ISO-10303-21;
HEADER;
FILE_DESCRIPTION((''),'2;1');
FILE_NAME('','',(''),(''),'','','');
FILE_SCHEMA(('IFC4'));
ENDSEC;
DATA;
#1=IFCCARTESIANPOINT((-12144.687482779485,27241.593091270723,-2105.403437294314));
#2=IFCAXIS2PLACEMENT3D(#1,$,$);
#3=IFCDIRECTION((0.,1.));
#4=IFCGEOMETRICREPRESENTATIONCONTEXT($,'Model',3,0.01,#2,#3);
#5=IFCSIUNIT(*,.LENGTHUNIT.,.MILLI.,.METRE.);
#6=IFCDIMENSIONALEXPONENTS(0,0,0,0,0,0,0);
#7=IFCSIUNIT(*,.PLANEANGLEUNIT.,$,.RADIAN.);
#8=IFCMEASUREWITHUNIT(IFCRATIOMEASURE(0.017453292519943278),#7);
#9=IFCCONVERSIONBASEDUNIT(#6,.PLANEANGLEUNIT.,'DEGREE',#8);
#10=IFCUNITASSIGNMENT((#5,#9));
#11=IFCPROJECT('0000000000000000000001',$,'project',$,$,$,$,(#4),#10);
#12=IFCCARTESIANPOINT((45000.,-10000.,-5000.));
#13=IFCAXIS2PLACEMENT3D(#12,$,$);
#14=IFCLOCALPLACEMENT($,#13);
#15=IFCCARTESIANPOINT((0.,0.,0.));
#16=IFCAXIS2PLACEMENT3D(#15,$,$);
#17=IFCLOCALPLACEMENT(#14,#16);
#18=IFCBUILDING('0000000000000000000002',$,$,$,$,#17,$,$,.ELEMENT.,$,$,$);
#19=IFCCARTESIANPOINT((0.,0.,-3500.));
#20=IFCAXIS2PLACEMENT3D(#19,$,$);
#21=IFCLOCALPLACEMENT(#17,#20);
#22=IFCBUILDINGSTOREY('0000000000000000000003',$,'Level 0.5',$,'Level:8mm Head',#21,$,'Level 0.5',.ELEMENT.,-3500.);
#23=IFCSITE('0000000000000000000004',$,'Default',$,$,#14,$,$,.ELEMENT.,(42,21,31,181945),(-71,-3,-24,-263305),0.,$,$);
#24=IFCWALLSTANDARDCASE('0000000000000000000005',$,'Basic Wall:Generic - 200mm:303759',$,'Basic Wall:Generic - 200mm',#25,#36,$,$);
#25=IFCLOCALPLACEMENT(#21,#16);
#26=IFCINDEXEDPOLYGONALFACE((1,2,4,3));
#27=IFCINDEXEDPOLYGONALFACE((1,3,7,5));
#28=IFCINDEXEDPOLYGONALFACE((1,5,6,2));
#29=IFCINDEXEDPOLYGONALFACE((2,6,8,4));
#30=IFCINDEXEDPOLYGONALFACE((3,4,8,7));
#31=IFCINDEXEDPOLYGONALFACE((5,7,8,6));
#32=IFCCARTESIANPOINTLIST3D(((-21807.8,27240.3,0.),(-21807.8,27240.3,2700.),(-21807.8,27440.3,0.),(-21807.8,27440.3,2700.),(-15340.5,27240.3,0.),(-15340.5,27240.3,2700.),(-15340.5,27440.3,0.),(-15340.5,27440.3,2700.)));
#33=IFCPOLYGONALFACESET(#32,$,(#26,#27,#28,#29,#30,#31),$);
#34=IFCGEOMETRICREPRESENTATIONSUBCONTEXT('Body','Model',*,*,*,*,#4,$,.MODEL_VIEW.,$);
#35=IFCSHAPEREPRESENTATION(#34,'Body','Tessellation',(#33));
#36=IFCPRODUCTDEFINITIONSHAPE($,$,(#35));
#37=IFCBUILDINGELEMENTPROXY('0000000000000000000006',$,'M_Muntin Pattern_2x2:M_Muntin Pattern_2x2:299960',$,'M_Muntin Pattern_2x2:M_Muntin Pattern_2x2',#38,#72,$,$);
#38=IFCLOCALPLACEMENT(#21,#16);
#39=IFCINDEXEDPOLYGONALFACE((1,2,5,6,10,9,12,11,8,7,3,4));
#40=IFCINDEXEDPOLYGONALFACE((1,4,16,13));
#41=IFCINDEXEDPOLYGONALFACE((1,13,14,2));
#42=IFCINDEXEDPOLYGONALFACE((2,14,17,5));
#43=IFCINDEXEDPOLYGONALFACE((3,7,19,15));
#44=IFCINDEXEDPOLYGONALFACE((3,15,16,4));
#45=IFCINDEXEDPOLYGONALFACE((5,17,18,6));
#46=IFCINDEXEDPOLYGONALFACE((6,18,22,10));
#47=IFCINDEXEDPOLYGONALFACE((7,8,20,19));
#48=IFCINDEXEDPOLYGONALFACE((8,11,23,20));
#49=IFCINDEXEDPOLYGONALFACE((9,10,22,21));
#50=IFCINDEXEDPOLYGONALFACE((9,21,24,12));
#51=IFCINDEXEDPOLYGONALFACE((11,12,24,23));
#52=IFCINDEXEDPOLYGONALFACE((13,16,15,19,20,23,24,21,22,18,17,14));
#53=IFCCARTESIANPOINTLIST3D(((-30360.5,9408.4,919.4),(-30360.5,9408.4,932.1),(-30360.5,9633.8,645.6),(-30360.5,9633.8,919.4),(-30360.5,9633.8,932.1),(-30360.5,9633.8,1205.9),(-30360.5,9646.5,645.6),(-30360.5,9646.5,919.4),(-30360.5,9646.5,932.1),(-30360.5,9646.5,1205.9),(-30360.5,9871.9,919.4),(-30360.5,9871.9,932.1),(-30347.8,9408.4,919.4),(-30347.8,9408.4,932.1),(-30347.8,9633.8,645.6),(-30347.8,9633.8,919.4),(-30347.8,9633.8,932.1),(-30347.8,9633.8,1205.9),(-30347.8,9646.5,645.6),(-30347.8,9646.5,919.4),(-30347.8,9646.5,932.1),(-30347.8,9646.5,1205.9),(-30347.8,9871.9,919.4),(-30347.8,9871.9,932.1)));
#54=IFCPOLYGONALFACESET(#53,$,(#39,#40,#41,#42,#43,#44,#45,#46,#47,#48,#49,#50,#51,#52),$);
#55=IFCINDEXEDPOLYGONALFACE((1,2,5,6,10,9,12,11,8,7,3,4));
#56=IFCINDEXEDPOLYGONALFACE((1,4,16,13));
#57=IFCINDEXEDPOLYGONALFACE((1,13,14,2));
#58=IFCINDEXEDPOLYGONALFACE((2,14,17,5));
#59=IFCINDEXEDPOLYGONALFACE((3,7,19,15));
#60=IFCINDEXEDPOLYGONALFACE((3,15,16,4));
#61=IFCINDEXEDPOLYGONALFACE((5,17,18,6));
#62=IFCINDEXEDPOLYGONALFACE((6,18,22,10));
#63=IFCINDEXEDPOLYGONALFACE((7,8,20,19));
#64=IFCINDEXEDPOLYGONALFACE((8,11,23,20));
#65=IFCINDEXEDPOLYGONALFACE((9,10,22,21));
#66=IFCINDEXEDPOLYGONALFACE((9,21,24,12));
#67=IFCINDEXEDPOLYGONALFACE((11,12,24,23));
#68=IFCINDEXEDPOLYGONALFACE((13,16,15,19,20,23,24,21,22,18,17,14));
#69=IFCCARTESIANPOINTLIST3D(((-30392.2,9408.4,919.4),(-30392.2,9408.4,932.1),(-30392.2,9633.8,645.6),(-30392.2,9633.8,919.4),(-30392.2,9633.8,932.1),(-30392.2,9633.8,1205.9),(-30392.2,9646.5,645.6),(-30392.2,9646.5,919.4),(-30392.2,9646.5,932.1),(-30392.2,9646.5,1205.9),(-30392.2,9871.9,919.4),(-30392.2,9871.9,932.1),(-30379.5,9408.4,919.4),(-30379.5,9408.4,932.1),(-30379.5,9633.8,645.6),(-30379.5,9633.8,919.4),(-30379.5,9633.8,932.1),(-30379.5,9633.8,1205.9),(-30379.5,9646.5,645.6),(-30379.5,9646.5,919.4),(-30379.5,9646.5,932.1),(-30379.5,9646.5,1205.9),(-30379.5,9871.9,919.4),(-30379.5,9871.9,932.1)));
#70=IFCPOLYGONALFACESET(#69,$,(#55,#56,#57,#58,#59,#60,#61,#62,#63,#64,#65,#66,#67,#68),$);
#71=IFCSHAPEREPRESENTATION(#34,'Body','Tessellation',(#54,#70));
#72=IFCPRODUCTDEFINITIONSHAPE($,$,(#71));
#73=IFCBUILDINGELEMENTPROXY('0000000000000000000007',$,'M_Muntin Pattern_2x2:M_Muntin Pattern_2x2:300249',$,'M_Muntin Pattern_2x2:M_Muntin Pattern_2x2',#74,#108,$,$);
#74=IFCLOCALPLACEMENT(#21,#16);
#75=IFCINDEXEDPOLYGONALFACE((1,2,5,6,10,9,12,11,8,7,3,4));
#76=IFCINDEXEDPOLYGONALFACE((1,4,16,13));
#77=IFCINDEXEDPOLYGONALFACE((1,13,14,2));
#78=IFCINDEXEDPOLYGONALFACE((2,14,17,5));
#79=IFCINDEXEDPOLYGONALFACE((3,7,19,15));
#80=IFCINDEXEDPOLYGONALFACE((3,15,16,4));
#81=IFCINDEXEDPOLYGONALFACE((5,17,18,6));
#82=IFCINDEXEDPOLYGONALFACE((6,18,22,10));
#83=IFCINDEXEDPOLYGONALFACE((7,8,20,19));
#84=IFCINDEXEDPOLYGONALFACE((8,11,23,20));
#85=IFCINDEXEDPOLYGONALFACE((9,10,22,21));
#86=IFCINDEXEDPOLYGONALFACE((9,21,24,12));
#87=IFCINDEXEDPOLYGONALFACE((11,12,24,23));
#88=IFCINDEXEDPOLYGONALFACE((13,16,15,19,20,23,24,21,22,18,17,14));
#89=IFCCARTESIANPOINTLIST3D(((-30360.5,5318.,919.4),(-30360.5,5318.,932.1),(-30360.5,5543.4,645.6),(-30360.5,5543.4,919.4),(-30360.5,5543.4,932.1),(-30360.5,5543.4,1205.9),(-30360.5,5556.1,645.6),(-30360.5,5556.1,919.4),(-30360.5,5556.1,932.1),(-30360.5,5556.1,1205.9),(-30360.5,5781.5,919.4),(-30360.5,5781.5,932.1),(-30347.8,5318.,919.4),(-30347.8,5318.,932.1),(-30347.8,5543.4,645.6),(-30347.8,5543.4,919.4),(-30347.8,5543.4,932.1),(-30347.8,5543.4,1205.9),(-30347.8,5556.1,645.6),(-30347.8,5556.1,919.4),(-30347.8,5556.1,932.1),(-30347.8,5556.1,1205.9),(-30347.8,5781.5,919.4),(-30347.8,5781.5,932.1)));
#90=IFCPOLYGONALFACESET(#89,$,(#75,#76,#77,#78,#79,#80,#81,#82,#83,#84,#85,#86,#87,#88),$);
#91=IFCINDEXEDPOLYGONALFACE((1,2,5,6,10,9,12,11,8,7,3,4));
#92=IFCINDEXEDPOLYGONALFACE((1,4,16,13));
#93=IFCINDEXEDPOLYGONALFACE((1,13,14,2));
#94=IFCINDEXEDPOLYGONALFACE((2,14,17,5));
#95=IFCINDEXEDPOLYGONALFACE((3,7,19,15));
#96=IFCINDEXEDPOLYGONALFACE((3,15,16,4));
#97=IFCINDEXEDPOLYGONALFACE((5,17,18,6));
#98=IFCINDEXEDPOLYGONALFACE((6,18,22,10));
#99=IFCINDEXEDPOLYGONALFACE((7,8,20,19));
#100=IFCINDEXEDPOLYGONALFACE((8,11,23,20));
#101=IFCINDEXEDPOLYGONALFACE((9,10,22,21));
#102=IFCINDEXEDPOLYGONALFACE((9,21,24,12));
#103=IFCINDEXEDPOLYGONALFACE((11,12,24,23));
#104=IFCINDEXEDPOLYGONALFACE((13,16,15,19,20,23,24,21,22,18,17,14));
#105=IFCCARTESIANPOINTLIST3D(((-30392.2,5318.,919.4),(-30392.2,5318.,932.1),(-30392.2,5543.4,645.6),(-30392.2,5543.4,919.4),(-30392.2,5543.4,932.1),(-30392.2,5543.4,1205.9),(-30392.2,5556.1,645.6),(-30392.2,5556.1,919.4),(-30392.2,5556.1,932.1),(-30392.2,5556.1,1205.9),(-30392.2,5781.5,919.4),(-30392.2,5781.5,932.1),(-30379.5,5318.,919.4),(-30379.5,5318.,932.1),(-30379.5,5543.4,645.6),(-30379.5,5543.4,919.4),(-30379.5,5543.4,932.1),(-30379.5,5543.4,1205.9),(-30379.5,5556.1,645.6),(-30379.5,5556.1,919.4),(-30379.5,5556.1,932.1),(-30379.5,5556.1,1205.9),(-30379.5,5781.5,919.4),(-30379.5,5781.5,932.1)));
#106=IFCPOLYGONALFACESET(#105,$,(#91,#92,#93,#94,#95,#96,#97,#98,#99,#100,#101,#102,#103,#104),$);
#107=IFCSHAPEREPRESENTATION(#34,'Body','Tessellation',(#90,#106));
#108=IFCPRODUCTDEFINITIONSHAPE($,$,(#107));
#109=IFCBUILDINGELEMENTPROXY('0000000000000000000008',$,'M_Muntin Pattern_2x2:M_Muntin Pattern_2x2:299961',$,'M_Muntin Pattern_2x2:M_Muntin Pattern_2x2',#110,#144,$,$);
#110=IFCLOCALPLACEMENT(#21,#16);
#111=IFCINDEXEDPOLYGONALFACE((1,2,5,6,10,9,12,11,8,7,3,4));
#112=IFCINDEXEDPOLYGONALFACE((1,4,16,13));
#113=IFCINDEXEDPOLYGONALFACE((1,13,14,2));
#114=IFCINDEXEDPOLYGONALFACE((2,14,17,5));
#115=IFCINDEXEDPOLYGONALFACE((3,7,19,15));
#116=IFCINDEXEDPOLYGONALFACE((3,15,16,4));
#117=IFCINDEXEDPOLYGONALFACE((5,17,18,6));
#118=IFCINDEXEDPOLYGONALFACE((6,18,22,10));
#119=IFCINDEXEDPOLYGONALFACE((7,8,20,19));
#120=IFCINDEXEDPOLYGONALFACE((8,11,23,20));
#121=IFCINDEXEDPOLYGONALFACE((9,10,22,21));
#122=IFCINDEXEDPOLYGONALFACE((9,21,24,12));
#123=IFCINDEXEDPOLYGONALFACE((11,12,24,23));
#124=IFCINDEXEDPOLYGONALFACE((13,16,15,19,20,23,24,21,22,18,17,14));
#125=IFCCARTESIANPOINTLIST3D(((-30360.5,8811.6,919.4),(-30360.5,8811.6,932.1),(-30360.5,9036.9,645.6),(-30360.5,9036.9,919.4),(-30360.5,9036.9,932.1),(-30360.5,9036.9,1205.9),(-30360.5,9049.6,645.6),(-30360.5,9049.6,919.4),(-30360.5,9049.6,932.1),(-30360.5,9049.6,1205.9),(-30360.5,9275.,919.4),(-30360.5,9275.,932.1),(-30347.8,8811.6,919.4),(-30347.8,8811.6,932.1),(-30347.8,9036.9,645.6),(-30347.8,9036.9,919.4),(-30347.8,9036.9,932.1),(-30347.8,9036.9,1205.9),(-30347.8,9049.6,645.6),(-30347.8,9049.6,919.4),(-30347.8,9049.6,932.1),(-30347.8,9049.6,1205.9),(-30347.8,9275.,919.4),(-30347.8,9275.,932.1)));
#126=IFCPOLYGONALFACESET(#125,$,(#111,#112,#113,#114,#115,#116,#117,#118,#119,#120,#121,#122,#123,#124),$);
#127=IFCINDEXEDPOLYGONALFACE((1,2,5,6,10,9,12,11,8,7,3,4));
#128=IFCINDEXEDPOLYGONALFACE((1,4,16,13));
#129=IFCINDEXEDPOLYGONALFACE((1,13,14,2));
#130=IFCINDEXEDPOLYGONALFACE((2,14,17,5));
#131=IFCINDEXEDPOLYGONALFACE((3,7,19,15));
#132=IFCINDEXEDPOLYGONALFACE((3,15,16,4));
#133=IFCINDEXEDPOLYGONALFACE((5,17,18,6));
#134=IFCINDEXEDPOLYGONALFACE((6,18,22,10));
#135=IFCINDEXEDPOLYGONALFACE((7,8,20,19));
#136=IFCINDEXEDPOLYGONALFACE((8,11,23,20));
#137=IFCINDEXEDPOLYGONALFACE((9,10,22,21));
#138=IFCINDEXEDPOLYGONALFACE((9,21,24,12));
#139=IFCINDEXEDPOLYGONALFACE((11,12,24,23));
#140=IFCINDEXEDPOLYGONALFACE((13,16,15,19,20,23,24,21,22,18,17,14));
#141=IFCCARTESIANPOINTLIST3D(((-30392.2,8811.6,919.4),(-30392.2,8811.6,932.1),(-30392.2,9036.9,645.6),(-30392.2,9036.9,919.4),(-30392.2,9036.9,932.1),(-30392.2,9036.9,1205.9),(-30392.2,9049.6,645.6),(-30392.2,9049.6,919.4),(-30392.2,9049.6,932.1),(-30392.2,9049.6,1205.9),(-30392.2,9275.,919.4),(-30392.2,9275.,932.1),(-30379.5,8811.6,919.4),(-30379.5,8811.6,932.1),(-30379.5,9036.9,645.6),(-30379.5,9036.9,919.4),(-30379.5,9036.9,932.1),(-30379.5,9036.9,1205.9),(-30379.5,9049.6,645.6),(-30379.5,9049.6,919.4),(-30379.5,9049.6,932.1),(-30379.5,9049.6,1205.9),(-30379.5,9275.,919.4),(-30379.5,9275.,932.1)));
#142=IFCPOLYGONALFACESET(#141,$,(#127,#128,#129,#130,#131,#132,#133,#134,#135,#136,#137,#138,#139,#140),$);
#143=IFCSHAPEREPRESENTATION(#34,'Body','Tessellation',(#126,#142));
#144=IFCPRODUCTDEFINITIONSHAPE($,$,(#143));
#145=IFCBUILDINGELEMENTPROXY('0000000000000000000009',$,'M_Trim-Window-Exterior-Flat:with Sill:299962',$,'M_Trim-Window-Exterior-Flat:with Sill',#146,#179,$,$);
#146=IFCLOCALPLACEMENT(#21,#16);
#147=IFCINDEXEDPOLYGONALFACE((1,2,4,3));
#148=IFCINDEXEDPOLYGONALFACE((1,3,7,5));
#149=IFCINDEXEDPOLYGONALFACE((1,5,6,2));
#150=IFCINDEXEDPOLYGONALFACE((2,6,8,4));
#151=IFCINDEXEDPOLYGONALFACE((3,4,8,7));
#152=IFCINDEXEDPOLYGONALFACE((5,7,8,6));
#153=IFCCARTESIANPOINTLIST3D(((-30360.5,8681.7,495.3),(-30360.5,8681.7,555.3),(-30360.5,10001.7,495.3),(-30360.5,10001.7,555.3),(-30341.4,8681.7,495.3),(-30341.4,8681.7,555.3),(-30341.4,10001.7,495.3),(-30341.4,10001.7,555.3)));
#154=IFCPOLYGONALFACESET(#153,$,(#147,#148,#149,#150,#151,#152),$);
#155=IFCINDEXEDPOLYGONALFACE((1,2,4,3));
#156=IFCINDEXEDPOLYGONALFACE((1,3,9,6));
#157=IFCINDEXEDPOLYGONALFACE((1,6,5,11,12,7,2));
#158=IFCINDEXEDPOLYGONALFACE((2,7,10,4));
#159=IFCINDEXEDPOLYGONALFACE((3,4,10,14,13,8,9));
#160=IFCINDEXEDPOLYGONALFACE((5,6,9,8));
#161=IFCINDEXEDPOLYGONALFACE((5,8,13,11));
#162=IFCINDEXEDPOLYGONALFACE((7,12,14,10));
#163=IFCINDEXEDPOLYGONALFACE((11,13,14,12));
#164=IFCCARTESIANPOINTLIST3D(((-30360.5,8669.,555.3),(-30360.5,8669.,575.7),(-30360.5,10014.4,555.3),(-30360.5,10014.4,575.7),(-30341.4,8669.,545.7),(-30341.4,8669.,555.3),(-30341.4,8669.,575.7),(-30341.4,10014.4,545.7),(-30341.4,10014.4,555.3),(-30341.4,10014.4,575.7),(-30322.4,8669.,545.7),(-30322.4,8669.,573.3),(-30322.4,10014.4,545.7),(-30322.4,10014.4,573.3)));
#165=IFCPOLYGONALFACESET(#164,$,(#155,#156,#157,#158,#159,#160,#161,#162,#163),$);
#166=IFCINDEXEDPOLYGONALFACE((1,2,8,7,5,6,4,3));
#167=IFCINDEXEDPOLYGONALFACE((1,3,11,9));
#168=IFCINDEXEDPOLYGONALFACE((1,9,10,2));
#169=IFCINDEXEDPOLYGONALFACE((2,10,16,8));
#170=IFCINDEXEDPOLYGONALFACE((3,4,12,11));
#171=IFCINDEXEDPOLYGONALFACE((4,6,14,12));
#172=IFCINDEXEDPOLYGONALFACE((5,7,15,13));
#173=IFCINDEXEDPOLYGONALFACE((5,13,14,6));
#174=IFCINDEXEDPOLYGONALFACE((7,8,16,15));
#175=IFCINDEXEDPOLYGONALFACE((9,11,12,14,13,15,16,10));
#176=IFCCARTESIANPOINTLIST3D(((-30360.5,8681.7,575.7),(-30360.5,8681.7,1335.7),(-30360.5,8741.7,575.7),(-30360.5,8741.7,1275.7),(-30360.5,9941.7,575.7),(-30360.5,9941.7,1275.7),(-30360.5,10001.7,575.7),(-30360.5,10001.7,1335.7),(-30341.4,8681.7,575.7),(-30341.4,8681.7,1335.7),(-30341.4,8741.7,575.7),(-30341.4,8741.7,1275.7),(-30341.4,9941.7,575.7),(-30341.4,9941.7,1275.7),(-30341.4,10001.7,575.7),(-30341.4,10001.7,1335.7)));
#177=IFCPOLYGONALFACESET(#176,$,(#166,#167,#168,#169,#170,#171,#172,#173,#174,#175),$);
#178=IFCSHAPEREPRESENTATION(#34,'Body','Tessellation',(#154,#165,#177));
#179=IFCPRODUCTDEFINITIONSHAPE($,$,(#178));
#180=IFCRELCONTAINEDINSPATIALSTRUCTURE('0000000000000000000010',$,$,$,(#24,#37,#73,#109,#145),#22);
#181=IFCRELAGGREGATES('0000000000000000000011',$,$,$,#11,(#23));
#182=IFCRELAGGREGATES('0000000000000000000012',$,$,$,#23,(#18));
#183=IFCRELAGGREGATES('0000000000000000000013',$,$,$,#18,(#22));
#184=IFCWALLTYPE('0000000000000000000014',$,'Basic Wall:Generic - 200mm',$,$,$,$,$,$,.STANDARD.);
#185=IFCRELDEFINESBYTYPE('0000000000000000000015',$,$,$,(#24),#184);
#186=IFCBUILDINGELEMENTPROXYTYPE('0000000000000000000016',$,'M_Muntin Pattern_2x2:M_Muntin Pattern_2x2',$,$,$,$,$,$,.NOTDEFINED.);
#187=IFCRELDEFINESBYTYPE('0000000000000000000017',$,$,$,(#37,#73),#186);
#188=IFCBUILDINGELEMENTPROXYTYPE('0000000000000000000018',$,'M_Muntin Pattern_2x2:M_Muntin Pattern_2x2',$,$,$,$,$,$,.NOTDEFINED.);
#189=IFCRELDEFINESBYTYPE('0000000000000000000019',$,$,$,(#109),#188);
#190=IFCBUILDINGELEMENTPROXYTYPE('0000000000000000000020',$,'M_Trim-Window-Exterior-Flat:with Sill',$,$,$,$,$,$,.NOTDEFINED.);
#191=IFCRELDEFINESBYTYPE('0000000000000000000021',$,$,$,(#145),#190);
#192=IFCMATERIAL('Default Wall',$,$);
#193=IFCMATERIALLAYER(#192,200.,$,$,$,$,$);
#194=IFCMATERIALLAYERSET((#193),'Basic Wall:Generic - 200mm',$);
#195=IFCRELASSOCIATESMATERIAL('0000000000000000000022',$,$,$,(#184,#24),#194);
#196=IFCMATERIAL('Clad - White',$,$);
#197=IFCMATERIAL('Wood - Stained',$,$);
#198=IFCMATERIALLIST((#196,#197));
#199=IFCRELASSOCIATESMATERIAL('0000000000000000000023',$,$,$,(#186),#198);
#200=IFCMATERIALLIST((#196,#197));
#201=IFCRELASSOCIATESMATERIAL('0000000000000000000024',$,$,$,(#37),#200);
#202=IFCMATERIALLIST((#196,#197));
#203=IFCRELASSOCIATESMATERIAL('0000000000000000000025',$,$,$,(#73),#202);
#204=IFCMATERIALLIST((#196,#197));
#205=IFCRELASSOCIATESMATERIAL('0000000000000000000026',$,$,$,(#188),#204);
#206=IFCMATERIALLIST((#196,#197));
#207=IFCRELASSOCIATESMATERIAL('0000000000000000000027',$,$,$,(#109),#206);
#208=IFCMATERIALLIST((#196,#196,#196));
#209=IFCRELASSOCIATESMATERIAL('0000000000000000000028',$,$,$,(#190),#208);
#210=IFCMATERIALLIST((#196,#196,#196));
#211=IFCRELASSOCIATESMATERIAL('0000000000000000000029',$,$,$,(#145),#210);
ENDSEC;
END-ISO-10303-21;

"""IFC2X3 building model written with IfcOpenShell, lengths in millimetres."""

from ifc_helpers import new_model, entity, si_unit, converted_unit, direction, frame, frame_2d, origin, place, context, subcontext, project, spatial, polyline, rectangle, outline, extrude, source, transform, mapped, material, material_list, layer, layer_set, layer_usage, type_object, type_shapes, element, save


model = new_model("IFC2X3")

# Units and contexts
model_context = context("Model", 3, precision=0.01, world=frame((-12144.687482779485, 27241.593091270723, -2105.403437294314)), true_north=direction((0.0, 1.0)))
body_context = subcontext(model_context, "Body", "Model", "MODEL_VIEW")
ifc_project = project(units=[si_unit("LENGTHUNIT", "METRE", prefix="MILLI"), converted_unit("PLANEANGLEUNIT", "DEGREE", entity("IfcRatioMeasure", 0.017453292519943278), si_unit("PLANEANGLEUNIT", "RADIAN"), dimensions=[0, 0, 0, 0, 0, 0, 0])], contexts=[model_context])

# Site, building, storey
site_placement = place(None, frame((45000.0, -10000.0, -5000.0)))
site = spatial("IfcSite", under=ifc_project, at=site_placement, Name="Default", CompositionType="ELEMENT", RefLatitude=(42, 21, 31, 181945), RefLongitude=(-71, -3, -24, -263305), RefElevation=0.0)
building_placement = place(site_placement, origin())
building = spatial("IfcBuilding", under=site, at=building_placement, CompositionType="ELEMENT")
storey_placement = place(building_placement, frame((0.0, 0.0, -3500.0)))
storey = spatial("IfcBuildingStorey", under=building, at=storey_placement, Name="Level 0.5", ObjectType="Level:8mm Head", LongName="Level 0.5", CompositionType="ELEMENT", Elevation=-3500.0)

# Shared definitions
ifc_material_1 = material(Name="Default Wall")
ifc_layer_1 = layer(ifc_material_1, 200.0)
ifc_layer_set_1 = layer_set([ifc_layer_1], Name="Basic Wall:Generic - 200mm")
wall_type_1 = type_object("IfcWallType", Name="Basic Wall:Generic - 200mm", PredefinedType="STANDARD", material=ifc_layer_set_1)

# Wall
ifc_layer_usage_1 = layer_usage(ifc_layer_set_1, "AXIS2", "NEGATIVE", 100.0)
wall_1_placement = place(storey_placement, frame((-15340.5, 27340.3, 0.0), z_axis=(0.0, 0.0, 1.0), x_axis=(-1.0, 0.0, 0.0)))
element("IfcWallStandardCase", 1, at=wall_1_placement, inside=storey, type_object=wall_type_1, material=ifc_layer_usage_1, Name="Basic Wall:Generic - 200mm:303759", ObjectType="Basic Wall:Generic - 200mm", context=body_context, shape_type="SweptSolid", body=[
    extrude(rectangle(XDim=6467.3, YDim=200.0, at=frame_2d((3233.6, 0.0), x_axis=(-1.0, 0.0))), origin(), (0.0, 0.0, 1.0), 2700.0),
])

# Building element proxies
ifc_material_2 = material(Name="Clad - White")
ifc_material_3 = material(Name="Wood - Stained")
ifc_material_list_1 = material_list([ifc_material_2, ifc_material_3])
ifc_material_list_2 = material_list([ifc_material_2, ifc_material_3])
building_element_proxy_type_1 = type_object("IfcBuildingElementProxyType", Name="M_Muntin Pattern_2x2:M_Muntin Pattern_2x2", PredefinedType="NOTDEFINED", material=ifc_material_list_2)
shared_shape_1 = source(origin(), body_context, "Body", "SweptSolid", [
    extrude(outline(polyline([(6.4, -6.4), (280.1, -6.4), (280.1, 6.3), (6.4, 6.3), (6.4, 231.7), (-6.3, 231.7), (-6.3, 6.3), (-280.2, 6.3), (-280.2, -6.4), (-6.3, -6.4), (-6.3, -231.7), (6.4, -231.7), (6.4, -6.4)])), frame((0.0, 9.5, 280.1), z_axis=(0.0, 1.0, 0.0), x_axis=(0.0, 0.0, 1.0)), (0.0, 0.0, 1.0), 12.7),
    extrude(outline(polyline([(6.4, -6.4), (280.2, -6.4), (280.2, 6.3), (6.4, 6.3), (6.4, 231.7), (-6.3, 231.7), (-6.3, 6.3), (-280.2, 6.3), (-280.2, -6.4), (-6.3, -6.4), (-6.3, -231.7), (6.4, -231.7), (6.4, -6.4)])), frame((0.0, -22.2, 280.2), z_axis=(0.0, 1.0, 0.0), x_axis=(0.0, 0.0, 1.0)), (0.0, 0.0, 1.0), 12.7),
])
type_shapes(building_element_proxy_type_1, [shared_shape_1])
proxy_1_placement = place(storey_placement, frame((-30370.0, 9640.1, 645.6), z_axis=(0.0, 0.0, 1.0), x_axis=(0.0, -1.0, 0.0)))
element("IfcBuildingElementProxy", 2, at=proxy_1_placement, inside=storey, type_object=building_element_proxy_type_1, material=ifc_material_list_1, Name="M_Muntin Pattern_2x2:M_Muntin Pattern_2x2:299960", ObjectType="M_Muntin Pattern_2x2:M_Muntin Pattern_2x2", context=body_context, shape_type="MappedRepresentation", body=[
    mapped(shared_shape_1, transform((0.0, 0.0, 0.0), scale=1.0)),
])
ifc_material_list_3 = material_list([ifc_material_2, ifc_material_3])
proxy_2_placement = place(storey_placement, frame((-30370.0, 5549.7, 645.6), z_axis=(0.0, 0.0, 1.0), x_axis=(0.0, -1.0, 0.0)))
element("IfcBuildingElementProxy", 3, at=proxy_2_placement, inside=storey, type_object=building_element_proxy_type_1, material=ifc_material_list_3, Name="M_Muntin Pattern_2x2:M_Muntin Pattern_2x2:300249", ObjectType="M_Muntin Pattern_2x2:M_Muntin Pattern_2x2", context=body_context, shape_type="MappedRepresentation", body=[
    mapped(shared_shape_1, transform((0.0, 0.0, 0.0), scale=1.0)),
])
ifc_material_list_4 = material_list([ifc_material_2, ifc_material_3])
ifc_material_list_5 = material_list([ifc_material_2, ifc_material_3])
building_element_proxy_type_2 = type_object("IfcBuildingElementProxyType", Name="M_Muntin Pattern_2x2:M_Muntin Pattern_2x2", PredefinedType="NOTDEFINED", material=ifc_material_list_5)
shared_shape_2 = source(origin(), body_context, "Body", "SweptSolid", [
    extrude(outline(polyline([(6.4, -6.4), (280.1, -6.4), (280.1, 6.3), (6.4, 6.3), (6.4, 231.7), (-6.3, 231.7), (-6.3, 6.3), (-280.2, 6.3), (-280.2, -6.4), (-6.3, -6.4), (-6.3, -231.7), (6.4, -231.7), (6.4, -6.4)])), frame((0.0, -22.2, 280.1), z_axis=(0.0, 1.0, 0.0), x_axis=(0.0, 0.0, 1.0)), (0.0, 0.0, 1.0), 12.7),
    extrude(outline(polyline([(6.4, -6.4), (280.2, -6.4), (280.2, 6.3), (6.4, 6.3), (6.4, 231.7), (-6.3, 231.7), (-6.3, 6.3), (-280.2, 6.3), (-280.2, -6.4), (-6.3, -6.4), (-6.3, -231.7), (6.4, -231.7), (6.4, -6.4)])), frame((0.0, 9.5, 280.2), z_axis=(0.0, 1.0, 0.0), x_axis=(0.0, 0.0, 1.0)), (0.0, 0.0, 1.0), 12.7),
])
type_shapes(building_element_proxy_type_2, [shared_shape_2])
proxy_3_placement = place(storey_placement, frame((-30370.0, 9043.3, 645.6), z_axis=(0.0, 0.0, 1.0), x_axis=(0.0, 1.0, 0.0)))
element("IfcBuildingElementProxy", 4, at=proxy_3_placement, inside=storey, type_object=building_element_proxy_type_2, material=ifc_material_list_4, Name="M_Muntin Pattern_2x2:M_Muntin Pattern_2x2:299961", ObjectType="M_Muntin Pattern_2x2:M_Muntin Pattern_2x2", context=body_context, shape_type="MappedRepresentation", body=[
    mapped(shared_shape_2, transform((0.0, 0.0, 0.0), scale=1.0)),
])
ifc_material_list_6 = material_list([ifc_material_2, ifc_material_2, ifc_material_2])
ifc_material_list_7 = material_list([ifc_material_2, ifc_material_2, ifc_material_2])
building_element_proxy_type_3 = type_object("IfcBuildingElementProxyType", Name="M_Trim-Window-Exterior-Flat:with Sill", PredefinedType="NOTDEFINED", material=ifc_material_list_7)
shared_shape_3 = source(origin(), body_context, "Body", "SweptSolid", [
    extrude(rectangle(XDim=1320.0, YDim=60.0, at=frame_2d((0.0, 0.0), x_axis=(1.0, 0.0))), frame((0.0, -750.4, 0.0), z_axis=(0.0, 0.0, 1.0), x_axis=(-1.0, 0.0, 0.0)), (0.0, 0.0, 1.0), 19.0),
    extrude(outline(polyline([(-19.0, -15.2), (0.0, -15.2), (0.0, -5.7), (19.0, -5.7), (19.0, 14.8), (0.0, 14.8), (-19.0, 12.3), (-19.0, -15.2)])), frame((-672.7, -714.8, 19.0), z_axis=(1.0, 0.0, 0.0), x_axis=(0.0, 0.0, -1.0)), (0.0, 0.0, 1.0), 1345.4),
    extrude(outline(polyline([(-395.0, -660.0), (365.0, -660.0), (365.0, -600.0), (-335.0, -600.0), (-335.0, 600.0), (365.0, 600.0), (365.0, 660.0), (-395.0, 660.0), (-395.0, -660.0)])), frame((0.0, -335.0, 0.0), z_axis=(0.0, 0.0, 1.0), x_axis=(0.0, -1.0, 0.0)), (0.0, 0.0, 1.0), 19.0),
])
type_shapes(building_element_proxy_type_3, [shared_shape_3])
proxy_4_placement = place(storey_placement, frame((-30360.5, 9341.7, 1275.7), z_axis=(1.0, 0.0, 0.0), x_axis=(0.0, 1.0, 0.0)))
element("IfcBuildingElementProxy", 5, at=proxy_4_placement, inside=storey, type_object=building_element_proxy_type_3, material=ifc_material_list_6, Name="M_Trim-Window-Exterior-Flat:with Sill:299962", ObjectType="M_Trim-Window-Exterior-Flat:with Sill", context=body_context, shape_type="MappedRepresentation", body=[
    mapped(shared_shape_3, transform((0.0, 0.0, 0.0), scale=1.0)),
])

save(model, "model.ifc")
